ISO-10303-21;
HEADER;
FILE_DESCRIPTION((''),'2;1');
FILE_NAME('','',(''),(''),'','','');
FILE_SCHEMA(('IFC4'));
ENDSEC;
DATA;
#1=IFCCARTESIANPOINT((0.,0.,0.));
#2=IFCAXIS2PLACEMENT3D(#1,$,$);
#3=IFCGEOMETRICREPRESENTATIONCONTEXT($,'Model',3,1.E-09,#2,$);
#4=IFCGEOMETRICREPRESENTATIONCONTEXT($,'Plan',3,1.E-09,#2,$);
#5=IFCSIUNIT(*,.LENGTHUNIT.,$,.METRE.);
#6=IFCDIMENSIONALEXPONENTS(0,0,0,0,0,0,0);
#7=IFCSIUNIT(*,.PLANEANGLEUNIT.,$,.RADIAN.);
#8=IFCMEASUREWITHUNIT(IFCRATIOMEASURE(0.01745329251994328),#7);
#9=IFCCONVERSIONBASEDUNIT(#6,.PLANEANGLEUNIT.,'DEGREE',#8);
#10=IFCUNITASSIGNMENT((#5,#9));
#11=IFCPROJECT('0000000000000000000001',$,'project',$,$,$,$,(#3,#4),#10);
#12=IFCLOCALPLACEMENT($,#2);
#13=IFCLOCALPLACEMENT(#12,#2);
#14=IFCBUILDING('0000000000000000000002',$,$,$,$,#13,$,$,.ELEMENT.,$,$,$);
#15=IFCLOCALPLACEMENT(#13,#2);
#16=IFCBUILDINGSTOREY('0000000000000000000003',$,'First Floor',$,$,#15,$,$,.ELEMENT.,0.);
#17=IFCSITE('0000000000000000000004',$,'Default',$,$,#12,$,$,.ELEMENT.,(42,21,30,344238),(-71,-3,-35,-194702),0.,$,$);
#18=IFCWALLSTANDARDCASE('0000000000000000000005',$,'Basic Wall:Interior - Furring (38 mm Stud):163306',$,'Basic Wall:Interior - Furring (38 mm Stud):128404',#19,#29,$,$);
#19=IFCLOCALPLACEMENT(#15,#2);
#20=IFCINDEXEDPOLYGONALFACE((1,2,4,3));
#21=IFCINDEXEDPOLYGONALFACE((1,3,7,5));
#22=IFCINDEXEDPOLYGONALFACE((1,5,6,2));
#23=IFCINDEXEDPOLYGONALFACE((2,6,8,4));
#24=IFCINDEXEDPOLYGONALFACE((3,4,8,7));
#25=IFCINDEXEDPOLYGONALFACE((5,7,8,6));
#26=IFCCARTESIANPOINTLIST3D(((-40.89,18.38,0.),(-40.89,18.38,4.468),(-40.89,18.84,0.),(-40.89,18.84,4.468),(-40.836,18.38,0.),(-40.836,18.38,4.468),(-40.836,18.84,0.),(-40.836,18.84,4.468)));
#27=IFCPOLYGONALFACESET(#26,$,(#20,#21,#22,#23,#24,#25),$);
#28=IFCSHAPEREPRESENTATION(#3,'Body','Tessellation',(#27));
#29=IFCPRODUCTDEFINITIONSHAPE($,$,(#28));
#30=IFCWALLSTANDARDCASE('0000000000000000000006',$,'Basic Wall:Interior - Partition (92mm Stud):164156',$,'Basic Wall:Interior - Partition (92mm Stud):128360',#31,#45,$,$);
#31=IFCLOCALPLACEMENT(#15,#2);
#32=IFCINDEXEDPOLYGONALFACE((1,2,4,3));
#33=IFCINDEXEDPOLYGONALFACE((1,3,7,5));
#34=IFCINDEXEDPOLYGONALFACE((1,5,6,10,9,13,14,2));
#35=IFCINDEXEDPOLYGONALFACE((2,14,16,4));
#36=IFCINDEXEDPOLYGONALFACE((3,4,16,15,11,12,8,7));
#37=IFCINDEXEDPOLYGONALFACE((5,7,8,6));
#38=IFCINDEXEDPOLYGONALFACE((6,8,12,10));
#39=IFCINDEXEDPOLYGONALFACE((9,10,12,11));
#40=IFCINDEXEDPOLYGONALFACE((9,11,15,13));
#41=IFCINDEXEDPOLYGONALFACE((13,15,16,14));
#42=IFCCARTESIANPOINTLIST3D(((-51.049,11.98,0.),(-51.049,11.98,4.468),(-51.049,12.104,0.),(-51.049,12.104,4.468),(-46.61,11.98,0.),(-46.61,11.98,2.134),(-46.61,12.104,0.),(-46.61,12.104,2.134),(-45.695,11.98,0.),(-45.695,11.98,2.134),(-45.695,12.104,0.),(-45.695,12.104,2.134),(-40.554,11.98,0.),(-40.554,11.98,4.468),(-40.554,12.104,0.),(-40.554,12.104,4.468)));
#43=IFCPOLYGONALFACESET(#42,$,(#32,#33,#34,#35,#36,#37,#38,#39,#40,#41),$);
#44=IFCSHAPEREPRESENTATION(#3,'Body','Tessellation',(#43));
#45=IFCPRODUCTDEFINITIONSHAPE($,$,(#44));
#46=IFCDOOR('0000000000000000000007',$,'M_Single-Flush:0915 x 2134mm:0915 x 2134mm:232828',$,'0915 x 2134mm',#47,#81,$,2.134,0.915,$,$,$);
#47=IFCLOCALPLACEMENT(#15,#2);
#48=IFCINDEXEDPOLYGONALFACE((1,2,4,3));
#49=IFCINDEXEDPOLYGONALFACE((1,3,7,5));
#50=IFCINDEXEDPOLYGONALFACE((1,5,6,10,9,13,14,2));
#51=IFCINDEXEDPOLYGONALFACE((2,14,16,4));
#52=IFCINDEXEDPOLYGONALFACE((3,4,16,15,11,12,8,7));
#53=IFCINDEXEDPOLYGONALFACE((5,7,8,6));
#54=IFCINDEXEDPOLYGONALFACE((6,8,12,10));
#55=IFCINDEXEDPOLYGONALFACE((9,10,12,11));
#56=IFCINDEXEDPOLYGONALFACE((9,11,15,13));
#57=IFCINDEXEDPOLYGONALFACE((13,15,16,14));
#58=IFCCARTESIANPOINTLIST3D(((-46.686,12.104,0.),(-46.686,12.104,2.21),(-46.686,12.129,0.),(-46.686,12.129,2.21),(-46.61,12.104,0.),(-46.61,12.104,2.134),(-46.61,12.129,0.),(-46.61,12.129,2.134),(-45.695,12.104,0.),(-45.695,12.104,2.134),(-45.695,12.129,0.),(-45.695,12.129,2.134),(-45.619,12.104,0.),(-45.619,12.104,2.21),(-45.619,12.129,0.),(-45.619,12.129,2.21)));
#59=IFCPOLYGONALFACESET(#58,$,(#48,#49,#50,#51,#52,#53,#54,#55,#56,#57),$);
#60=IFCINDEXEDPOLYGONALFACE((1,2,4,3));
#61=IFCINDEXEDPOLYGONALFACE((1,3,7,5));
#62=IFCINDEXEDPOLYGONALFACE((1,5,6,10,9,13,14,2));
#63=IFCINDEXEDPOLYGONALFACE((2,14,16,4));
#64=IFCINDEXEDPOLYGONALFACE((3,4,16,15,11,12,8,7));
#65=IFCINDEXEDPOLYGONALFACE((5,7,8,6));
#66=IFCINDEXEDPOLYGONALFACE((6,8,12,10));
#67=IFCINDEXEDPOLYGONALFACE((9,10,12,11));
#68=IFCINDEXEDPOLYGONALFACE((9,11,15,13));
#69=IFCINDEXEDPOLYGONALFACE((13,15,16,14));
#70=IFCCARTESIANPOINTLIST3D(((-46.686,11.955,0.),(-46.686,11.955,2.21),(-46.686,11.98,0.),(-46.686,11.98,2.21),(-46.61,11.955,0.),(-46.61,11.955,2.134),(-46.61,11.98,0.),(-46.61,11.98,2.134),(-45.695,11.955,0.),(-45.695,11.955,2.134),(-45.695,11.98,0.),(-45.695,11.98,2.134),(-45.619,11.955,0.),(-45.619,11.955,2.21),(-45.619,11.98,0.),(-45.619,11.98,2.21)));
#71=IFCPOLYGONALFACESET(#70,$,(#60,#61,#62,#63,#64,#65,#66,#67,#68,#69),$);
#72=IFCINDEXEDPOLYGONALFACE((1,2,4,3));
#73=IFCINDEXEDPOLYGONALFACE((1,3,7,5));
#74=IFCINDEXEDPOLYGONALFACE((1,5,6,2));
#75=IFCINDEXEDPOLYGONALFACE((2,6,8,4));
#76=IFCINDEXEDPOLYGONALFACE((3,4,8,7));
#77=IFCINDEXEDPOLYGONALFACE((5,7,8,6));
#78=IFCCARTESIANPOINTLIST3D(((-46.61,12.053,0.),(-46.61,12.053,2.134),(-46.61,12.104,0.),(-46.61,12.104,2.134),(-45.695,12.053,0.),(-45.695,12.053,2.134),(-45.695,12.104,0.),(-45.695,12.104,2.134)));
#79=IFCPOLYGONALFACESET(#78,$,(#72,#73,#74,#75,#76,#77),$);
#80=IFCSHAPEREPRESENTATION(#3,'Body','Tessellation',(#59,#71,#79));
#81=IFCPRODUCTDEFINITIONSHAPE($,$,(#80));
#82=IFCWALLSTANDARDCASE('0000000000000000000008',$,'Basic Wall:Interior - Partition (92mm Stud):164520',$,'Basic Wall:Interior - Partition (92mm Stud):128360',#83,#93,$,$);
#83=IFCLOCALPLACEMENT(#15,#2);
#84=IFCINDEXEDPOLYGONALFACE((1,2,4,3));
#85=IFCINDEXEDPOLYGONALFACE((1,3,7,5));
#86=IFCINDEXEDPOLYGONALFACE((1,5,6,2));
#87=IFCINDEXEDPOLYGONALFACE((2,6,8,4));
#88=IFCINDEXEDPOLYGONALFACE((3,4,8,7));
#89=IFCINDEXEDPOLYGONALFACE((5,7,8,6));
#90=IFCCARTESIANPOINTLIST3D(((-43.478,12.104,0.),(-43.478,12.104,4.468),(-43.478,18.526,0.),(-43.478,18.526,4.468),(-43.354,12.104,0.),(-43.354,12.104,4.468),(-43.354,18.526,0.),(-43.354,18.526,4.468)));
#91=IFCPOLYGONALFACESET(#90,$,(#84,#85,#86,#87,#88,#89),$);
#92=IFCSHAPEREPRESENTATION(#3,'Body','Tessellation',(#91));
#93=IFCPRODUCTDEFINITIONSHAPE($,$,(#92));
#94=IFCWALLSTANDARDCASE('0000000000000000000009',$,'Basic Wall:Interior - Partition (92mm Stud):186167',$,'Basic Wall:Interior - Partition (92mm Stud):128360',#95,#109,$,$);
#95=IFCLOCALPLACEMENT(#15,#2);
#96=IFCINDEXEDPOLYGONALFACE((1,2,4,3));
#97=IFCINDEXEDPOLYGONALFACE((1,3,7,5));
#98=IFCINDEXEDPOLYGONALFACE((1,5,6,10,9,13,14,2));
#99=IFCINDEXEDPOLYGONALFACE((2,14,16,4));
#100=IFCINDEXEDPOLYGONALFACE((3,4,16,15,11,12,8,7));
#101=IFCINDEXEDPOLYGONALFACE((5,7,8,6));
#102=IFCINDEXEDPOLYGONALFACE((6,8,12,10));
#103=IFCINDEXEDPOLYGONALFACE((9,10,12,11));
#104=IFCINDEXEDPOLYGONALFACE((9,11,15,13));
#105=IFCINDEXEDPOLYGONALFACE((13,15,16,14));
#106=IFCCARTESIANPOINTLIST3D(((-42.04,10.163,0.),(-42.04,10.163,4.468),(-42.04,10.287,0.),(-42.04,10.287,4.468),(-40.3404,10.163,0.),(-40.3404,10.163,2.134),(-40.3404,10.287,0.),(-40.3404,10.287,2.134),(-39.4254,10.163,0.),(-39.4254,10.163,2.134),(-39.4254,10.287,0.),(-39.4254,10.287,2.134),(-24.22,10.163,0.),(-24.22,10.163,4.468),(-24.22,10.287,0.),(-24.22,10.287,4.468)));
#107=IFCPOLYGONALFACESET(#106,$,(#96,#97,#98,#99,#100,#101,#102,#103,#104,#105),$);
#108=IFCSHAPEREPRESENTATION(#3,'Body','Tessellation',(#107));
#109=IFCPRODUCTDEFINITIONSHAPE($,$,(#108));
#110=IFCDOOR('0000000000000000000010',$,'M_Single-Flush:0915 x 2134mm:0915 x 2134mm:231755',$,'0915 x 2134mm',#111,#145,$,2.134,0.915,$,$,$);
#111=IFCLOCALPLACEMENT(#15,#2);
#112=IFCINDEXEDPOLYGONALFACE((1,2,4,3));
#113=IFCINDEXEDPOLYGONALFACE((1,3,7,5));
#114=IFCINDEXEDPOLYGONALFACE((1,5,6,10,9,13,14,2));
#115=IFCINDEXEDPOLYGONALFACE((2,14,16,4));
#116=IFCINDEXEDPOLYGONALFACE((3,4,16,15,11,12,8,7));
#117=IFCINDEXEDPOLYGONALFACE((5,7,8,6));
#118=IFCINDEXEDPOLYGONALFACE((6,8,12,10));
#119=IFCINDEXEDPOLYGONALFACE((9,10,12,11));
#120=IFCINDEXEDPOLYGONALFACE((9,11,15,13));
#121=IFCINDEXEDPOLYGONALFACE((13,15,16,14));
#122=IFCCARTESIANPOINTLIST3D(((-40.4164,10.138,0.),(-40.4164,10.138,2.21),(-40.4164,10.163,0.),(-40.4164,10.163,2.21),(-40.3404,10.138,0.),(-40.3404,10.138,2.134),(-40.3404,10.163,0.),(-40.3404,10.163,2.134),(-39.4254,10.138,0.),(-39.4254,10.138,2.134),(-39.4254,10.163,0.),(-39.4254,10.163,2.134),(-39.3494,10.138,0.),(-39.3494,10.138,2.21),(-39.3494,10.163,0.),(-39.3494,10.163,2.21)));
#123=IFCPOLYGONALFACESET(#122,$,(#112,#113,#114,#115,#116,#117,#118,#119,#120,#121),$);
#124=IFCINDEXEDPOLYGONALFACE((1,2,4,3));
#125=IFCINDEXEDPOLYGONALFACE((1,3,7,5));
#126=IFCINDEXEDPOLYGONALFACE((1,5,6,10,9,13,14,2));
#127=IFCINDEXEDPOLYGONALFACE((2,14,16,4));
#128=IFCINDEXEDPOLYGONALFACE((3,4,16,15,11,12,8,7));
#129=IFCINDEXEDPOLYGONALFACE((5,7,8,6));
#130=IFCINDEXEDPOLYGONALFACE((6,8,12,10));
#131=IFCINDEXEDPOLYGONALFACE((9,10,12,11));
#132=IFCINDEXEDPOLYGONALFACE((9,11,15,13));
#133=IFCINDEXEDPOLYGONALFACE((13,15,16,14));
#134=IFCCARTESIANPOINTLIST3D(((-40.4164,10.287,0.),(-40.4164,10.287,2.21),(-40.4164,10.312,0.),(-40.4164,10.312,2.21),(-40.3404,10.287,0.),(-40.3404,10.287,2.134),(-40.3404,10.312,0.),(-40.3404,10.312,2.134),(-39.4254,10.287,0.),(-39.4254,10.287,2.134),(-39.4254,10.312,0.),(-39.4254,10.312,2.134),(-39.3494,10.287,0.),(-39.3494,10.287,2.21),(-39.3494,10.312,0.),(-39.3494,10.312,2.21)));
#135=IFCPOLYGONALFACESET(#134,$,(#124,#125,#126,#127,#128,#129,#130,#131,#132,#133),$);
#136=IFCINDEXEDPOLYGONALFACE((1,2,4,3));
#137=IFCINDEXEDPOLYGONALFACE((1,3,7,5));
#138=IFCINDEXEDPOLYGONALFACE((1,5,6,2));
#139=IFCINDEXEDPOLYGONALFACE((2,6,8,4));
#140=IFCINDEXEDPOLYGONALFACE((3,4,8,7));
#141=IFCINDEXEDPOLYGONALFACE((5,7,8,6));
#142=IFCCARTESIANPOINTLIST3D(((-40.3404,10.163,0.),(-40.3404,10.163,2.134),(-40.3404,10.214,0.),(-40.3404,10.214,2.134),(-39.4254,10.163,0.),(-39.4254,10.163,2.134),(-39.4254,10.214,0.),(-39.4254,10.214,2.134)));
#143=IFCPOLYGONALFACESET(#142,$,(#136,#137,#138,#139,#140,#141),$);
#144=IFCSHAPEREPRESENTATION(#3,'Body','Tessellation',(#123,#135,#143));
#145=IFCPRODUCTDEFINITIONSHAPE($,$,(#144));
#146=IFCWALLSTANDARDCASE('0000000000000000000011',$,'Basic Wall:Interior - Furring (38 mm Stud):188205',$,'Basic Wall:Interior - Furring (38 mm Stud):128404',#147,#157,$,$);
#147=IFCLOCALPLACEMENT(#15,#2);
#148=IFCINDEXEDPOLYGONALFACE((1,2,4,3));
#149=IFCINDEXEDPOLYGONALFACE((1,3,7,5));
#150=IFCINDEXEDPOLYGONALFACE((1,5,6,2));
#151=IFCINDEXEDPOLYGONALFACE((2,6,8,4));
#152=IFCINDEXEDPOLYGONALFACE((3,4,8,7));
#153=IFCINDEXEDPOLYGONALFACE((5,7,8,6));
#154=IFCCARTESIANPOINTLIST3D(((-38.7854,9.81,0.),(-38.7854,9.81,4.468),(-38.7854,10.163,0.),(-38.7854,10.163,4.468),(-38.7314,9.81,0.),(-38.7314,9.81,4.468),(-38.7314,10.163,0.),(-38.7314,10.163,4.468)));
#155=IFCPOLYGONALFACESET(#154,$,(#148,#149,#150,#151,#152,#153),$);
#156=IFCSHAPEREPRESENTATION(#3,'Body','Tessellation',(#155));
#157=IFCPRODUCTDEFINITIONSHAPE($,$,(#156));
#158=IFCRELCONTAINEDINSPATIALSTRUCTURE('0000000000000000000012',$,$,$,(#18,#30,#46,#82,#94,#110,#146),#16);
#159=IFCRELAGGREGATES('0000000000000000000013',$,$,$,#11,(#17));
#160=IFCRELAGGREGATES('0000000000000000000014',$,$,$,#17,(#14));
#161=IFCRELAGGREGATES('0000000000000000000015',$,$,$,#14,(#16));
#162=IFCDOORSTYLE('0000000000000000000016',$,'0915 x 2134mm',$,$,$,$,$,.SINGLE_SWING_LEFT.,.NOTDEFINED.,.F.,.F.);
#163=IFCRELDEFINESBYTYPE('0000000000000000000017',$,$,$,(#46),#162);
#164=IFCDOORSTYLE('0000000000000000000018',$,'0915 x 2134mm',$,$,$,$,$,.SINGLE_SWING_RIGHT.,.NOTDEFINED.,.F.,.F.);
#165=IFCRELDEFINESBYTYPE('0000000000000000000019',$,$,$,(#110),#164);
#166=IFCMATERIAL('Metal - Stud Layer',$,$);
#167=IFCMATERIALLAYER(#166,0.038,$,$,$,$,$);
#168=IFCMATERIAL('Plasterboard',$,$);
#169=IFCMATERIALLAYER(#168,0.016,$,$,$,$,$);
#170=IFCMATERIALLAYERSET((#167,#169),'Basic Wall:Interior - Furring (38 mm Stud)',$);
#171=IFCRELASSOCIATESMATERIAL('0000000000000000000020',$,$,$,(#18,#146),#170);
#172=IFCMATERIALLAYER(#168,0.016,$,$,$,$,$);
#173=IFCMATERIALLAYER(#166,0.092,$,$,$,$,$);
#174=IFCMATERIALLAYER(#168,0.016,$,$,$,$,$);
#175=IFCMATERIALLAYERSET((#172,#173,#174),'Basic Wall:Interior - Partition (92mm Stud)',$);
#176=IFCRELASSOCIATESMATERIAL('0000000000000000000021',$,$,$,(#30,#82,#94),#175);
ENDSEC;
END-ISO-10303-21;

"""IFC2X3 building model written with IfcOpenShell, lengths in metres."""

from ifc_helpers import new_model, entity, si_unit, converted_unit, frame, frame_2d, origin, origin_2d_with_axis, place, context, project, spatial, polyline, rectangle, outline, extrude, source, transform, mapped, material, layer, layer_set, layer_usage, type_object, type_shapes, element, fill, save


model = new_model("IFC2X3")

# Units and contexts
model_context = context("Model", 3, precision=1e-09, world=origin())
plan_context = context("Plan", 3, precision=1e-09, world=origin())
ifc_project = project(units=[si_unit("LENGTHUNIT", "METRE"), converted_unit("PLANEANGLEUNIT", "DEGREE", entity("IfcRatioMeasure", 0.01745329251994328), si_unit("PLANEANGLEUNIT", "RADIAN"), dimensions=[0, 0, 0, 0, 0, 0, 0])], contexts=[model_context, plan_context])

# Site, building, storey
site_placement = place(None, origin())
site = spatial("IfcSite", under=ifc_project, at=site_placement, Name="Default", CompositionType="ELEMENT", RefLatitude=(42, 21, 30, 344238), RefLongitude=(-71, -3, -35, -194702), RefElevation=0.0)
building_placement = place(site_placement, origin())
building = spatial("IfcBuilding", under=site, at=building_placement, CompositionType="ELEMENT")
storey_placement = place(building_placement, origin())
storey = spatial("IfcBuildingStorey", under=building, at=storey_placement, Name="First Floor", CompositionType="ELEMENT", Elevation=0.0)

# Wall
ifc_material_1 = material(Name="Metal - Stud Layer")
ifc_layer_1 = layer(ifc_material_1, 0.038)
ifc_material_2 = material(Name="Plasterboard")
ifc_layer_2 = layer(ifc_material_2, 0.016)
ifc_layer_set_1 = layer_set([ifc_layer_1, ifc_layer_2], Name="Basic Wall:Interior - Furring (38 mm Stud)")
ifc_layer_usage_1 = layer_usage(ifc_layer_set_1, "AXIS2", "POSITIVE", -0.027)
wall_1_placement = place(storey_placement, frame((-40.863, 18.38, 0.0), z_axis=(0.0, 0.0, 1.0), x_axis=(0.0, 1.0, 0.0)))
element("IfcWallStandardCase", 1, at=wall_1_placement, inside=storey, material=ifc_layer_usage_1, Name="Basic Wall:Interior - Furring (38 mm Stud):163306", ObjectType="Basic Wall:Interior - Furring (38 mm Stud):128404", context=model_context, shape_type="SweptSolid", body=[
    extrude(rectangle(XDim=0.46, YDim=0.054, at=frame_2d((0.23, 0.0), x_axis=(-1.0, 0.0))), origin(), (0.0, 0.0, 1.0), 4.468),
])

# Wall, opening, door
ifc_layer_3 = layer(ifc_material_2, 0.016)
ifc_layer_4 = layer(ifc_material_1, 0.092)
ifc_layer_5 = layer(ifc_material_2, 0.016)
ifc_layer_set_2 = layer_set([ifc_layer_3, ifc_layer_4, ifc_layer_5], Name="Basic Wall:Interior - Partition (92mm Stud)")
ifc_layer_usage_2 = layer_usage(ifc_layer_set_2, "AXIS2", "NEGATIVE", 0.062)
wall_2_placement = place(storey_placement, frame((-40.554, 12.042, 0.0), z_axis=(0.0, 0.0, 1.0), x_axis=(-1.0, 0.0, 0.0)))
wall_2 = element("IfcWallStandardCase", 2, at=wall_2_placement, inside=storey, material=ifc_layer_usage_2, Name="Basic Wall:Interior - Partition (92mm Stud):164156", ObjectType="Basic Wall:Interior - Partition (92mm Stud):128360", context=model_context, shape_type="SweptSolid", body=[
    extrude(rectangle(XDim=10.495, YDim=0.124, at=frame_2d((5.2475, 0.0), x_axis=(-1.0, 0.0))), origin(), (0.0, 0.0, 1.0), 4.468),
])
opening_1_placement = place(wall_2_placement, frame((6.056, 0.062, 0.0)))
opening_1 = element("IfcOpeningElement", 3, at=opening_1_placement, cuts=wall_2, ObjectType="Opening", context=model_context, shape_type="SweptSolid", body=[
    extrude(rectangle(XDim=0.915, YDim=2.134, at=frame_2d((1.067, 0.4575), x_axis=(0.0, -1.0))), frame((0.0, 0.0, 0.0), z_axis=(0.0, -1.0, 0.0), x_axis=(0.0, 0.0, 1.0)), (0.0, 0.0, 1.0), 0.124),
])
door_style_1 = type_object("IfcDoorStyle", Name="0915 x 2134mm", ConstructionType="NOTDEFINED", OperationType="SINGLE_SWING_LEFT", ParameterTakesPrecedence=False, Sizeable=False)
shared_shape_1 = source(origin(), model_context, "Body", "SweptSolid", [
    extrude(outline(polyline([(-0.5335, -1.124), (0.5335, -1.124), (0.5335, 1.086), (0.4575, 1.086), (0.4575, -1.048), (-0.4575, -1.048), (-0.4575, 1.086), (-0.5335, 1.086), (-0.5335, -1.124)])), frame((0.4575, 0.149, 1.086), z_axis=(0.0, -1.0, 0.0), x_axis=(-1.0, 0.0, 0.0)), (0.0, 0.0, 1.0), 0.025),
    extrude(outline(polyline([(-1.124, -0.5335), (1.086, -0.5335), (1.086, -0.4575), (-1.048, -0.4575), (-1.048, 0.4575), (1.086, 0.4575), (1.086, 0.5335), (-1.124, 0.5335), (-1.124, -0.5335)])), frame((0.4575, 0.0, 1.086), z_axis=(0.0, -1.0, 0.0), x_axis=(0.0, 0.0, -1.0)), (0.0, 0.0, 1.0), 0.025),
    extrude(rectangle(XDim=0.915, YDim=0.051, at=origin_2d_with_axis()), frame((0.4575, 0.0985, 0.0)), (0.0, 0.0, 1.0), 2.134),
])
type_shapes(door_style_1, [shared_shape_1])
door_1_placement = place(opening_1_placement, frame((0.0, 0.0, 0.0), z_axis=(0.0, 0.0, 1.0), x_axis=(-1.0, 0.0, 0.0)))
door_1 = element("IfcDoor", 4, at=door_1_placement, inside=storey, type_object=door_style_1, Name="M_Single-Flush:0915 x 2134mm:0915 x 2134mm:232828", ObjectType="0915 x 2134mm", OverallHeight=2.134, OverallWidth=0.915, context=model_context, shape_type="MappedRepresentation", body=[
    mapped(shared_shape_1, transform((0.0, 0.0, 0.0), scale=1.0)),
])
fill(opening_1, door_1)

# Wall
ifc_layer_usage_3 = layer_usage(ifc_layer_set_2, "AXIS2", "NEGATIVE", 0.062)
wall_3_placement = place(storey_placement, frame((-43.416, 12.104, 0.0), z_axis=(0.0, 0.0, 1.0), x_axis=(0.0, 1.0, 0.0)))
element("IfcWallStandardCase", 5, at=wall_3_placement, inside=storey, material=ifc_layer_usage_3, Name="Basic Wall:Interior - Partition (92mm Stud):164520", ObjectType="Basic Wall:Interior - Partition (92mm Stud):128360", context=model_context, shape_type="SweptSolid", body=[
    extrude(rectangle(XDim=6.422, YDim=0.124, at=frame_2d((3.211, 0.0), x_axis=(-1.0, 0.0))), origin(), (0.0, 0.0, 1.0), 4.468),
])

# Wall, opening, door
ifc_layer_usage_4 = layer_usage(ifc_layer_set_2, "AXIS2", "NEGATIVE", 0.062)
wall_4_placement = place(storey_placement, frame((-42.04, 10.225, 0.0)))
wall_4 = element("IfcWallStandardCase", 6, at=wall_4_placement, inside=storey, material=ifc_layer_usage_4, Name="Basic Wall:Interior - Partition (92mm Stud):186167", ObjectType="Basic Wall:Interior - Partition (92mm Stud):128360", context=model_context, shape_type="SweptSolid", body=[
    extrude(rectangle(XDim=17.82, YDim=0.124, at=frame_2d((8.91, 0.0), x_axis=(-1.0, 0.0))), origin(), (0.0, 0.0, 1.0), 4.468),
])
opening_2_placement = place(wall_4_placement, frame((2.6146, 0.062, 0.0)))
opening_2 = element("IfcOpeningElement", 7, at=opening_2_placement, cuts=wall_4, ObjectType="Opening", context=model_context, shape_type="SweptSolid", body=[
    extrude(rectangle(XDim=0.915, YDim=2.134, at=frame_2d((1.067, 0.4575), x_axis=(0.0, 1.0))), frame((0.0, 0.0, 0.0), z_axis=(0.0, -1.0, 0.0), x_axis=(0.0, 0.0, 1.0)), (0.0, 0.0, 1.0), 0.124),
])
door_style_2 = type_object("IfcDoorStyle", Name="0915 x 2134mm", ConstructionType="NOTDEFINED", OperationType="SINGLE_SWING_RIGHT", ParameterTakesPrecedence=False, Sizeable=False)
shared_shape_2 = source(origin(), model_context, "Body", "SweptSolid", [
    extrude(outline(polyline([(-0.5335, -1.124), (0.5335, -1.124), (0.5335, 1.086), (0.4575, 1.086), (0.4575, -1.048), (-0.4575, -1.048), (-0.4575, 1.086), (-0.5335, 1.086), (-0.5335, -1.124)])), frame((0.4575, 0.124, 1.086), z_axis=(0.0, 1.0, 0.0), x_axis=(1.0, 0.0, 0.0)), (0.0, 0.0, 1.0), 0.025),
    extrude(outline(polyline([(-1.124, -0.5335), (1.086, -0.5335), (1.086, -0.4575), (-1.048, -0.4575), (-1.048, 0.4575), (1.086, 0.4575), (1.086, 0.5335), (-1.124, 0.5335), (-1.124, -0.5335)])), frame((0.4575, -0.025, 1.086), z_axis=(0.0, 1.0, 0.0), x_axis=(0.0, 0.0, -1.0)), (0.0, 0.0, 1.0), 0.025),
    extrude(rectangle(XDim=0.051, YDim=0.915, at=origin_2d_with_axis()), frame((0.4575, 0.0985, 0.0), z_axis=(0.0, 0.0, 1.0), x_axis=(0.0, 1.0, 0.0)), (0.0, 0.0, 1.0), 2.134),
])
type_shapes(door_style_2, [shared_shape_2])
door_2_placement = place(opening_2_placement, frame((0.0, 0.0, 0.0), z_axis=(0.0, 0.0, 1.0), x_axis=(-1.0, 0.0, 0.0)))
door_2 = element("IfcDoor", 8, at=door_2_placement, inside=storey, type_object=door_style_2, Name="M_Single-Flush:0915 x 2134mm:0915 x 2134mm:231755", ObjectType="0915 x 2134mm", OverallHeight=2.134, OverallWidth=0.915, context=model_context, shape_type="MappedRepresentation", body=[
    mapped(shared_shape_2, transform((0.0, 0.0, 0.0), scale=1.0)),
])
fill(opening_2, door_2)

# Wall
ifc_layer_usage_5 = layer_usage(ifc_layer_set_1, "AXIS2", "POSITIVE", -0.027)
wall_5_placement = place(storey_placement, frame((-38.7584, 9.81, 0.0), z_axis=(0.0, 0.0, 1.0), x_axis=(0.0, 1.0, 0.0)))
element("IfcWallStandardCase", 9, at=wall_5_placement, inside=storey, material=ifc_layer_usage_5, Name="Basic Wall:Interior - Furring (38 mm Stud):188205", ObjectType="Basic Wall:Interior - Furring (38 mm Stud):128404", context=model_context, shape_type="SweptSolid", body=[
    extrude(rectangle(XDim=0.353, YDim=0.054, at=frame_2d((0.1765, 0.0), x_axis=(-1.0, 0.0))), origin(), (0.0, 0.0, 1.0), 4.468),
])

save(model, "model.ifc")
